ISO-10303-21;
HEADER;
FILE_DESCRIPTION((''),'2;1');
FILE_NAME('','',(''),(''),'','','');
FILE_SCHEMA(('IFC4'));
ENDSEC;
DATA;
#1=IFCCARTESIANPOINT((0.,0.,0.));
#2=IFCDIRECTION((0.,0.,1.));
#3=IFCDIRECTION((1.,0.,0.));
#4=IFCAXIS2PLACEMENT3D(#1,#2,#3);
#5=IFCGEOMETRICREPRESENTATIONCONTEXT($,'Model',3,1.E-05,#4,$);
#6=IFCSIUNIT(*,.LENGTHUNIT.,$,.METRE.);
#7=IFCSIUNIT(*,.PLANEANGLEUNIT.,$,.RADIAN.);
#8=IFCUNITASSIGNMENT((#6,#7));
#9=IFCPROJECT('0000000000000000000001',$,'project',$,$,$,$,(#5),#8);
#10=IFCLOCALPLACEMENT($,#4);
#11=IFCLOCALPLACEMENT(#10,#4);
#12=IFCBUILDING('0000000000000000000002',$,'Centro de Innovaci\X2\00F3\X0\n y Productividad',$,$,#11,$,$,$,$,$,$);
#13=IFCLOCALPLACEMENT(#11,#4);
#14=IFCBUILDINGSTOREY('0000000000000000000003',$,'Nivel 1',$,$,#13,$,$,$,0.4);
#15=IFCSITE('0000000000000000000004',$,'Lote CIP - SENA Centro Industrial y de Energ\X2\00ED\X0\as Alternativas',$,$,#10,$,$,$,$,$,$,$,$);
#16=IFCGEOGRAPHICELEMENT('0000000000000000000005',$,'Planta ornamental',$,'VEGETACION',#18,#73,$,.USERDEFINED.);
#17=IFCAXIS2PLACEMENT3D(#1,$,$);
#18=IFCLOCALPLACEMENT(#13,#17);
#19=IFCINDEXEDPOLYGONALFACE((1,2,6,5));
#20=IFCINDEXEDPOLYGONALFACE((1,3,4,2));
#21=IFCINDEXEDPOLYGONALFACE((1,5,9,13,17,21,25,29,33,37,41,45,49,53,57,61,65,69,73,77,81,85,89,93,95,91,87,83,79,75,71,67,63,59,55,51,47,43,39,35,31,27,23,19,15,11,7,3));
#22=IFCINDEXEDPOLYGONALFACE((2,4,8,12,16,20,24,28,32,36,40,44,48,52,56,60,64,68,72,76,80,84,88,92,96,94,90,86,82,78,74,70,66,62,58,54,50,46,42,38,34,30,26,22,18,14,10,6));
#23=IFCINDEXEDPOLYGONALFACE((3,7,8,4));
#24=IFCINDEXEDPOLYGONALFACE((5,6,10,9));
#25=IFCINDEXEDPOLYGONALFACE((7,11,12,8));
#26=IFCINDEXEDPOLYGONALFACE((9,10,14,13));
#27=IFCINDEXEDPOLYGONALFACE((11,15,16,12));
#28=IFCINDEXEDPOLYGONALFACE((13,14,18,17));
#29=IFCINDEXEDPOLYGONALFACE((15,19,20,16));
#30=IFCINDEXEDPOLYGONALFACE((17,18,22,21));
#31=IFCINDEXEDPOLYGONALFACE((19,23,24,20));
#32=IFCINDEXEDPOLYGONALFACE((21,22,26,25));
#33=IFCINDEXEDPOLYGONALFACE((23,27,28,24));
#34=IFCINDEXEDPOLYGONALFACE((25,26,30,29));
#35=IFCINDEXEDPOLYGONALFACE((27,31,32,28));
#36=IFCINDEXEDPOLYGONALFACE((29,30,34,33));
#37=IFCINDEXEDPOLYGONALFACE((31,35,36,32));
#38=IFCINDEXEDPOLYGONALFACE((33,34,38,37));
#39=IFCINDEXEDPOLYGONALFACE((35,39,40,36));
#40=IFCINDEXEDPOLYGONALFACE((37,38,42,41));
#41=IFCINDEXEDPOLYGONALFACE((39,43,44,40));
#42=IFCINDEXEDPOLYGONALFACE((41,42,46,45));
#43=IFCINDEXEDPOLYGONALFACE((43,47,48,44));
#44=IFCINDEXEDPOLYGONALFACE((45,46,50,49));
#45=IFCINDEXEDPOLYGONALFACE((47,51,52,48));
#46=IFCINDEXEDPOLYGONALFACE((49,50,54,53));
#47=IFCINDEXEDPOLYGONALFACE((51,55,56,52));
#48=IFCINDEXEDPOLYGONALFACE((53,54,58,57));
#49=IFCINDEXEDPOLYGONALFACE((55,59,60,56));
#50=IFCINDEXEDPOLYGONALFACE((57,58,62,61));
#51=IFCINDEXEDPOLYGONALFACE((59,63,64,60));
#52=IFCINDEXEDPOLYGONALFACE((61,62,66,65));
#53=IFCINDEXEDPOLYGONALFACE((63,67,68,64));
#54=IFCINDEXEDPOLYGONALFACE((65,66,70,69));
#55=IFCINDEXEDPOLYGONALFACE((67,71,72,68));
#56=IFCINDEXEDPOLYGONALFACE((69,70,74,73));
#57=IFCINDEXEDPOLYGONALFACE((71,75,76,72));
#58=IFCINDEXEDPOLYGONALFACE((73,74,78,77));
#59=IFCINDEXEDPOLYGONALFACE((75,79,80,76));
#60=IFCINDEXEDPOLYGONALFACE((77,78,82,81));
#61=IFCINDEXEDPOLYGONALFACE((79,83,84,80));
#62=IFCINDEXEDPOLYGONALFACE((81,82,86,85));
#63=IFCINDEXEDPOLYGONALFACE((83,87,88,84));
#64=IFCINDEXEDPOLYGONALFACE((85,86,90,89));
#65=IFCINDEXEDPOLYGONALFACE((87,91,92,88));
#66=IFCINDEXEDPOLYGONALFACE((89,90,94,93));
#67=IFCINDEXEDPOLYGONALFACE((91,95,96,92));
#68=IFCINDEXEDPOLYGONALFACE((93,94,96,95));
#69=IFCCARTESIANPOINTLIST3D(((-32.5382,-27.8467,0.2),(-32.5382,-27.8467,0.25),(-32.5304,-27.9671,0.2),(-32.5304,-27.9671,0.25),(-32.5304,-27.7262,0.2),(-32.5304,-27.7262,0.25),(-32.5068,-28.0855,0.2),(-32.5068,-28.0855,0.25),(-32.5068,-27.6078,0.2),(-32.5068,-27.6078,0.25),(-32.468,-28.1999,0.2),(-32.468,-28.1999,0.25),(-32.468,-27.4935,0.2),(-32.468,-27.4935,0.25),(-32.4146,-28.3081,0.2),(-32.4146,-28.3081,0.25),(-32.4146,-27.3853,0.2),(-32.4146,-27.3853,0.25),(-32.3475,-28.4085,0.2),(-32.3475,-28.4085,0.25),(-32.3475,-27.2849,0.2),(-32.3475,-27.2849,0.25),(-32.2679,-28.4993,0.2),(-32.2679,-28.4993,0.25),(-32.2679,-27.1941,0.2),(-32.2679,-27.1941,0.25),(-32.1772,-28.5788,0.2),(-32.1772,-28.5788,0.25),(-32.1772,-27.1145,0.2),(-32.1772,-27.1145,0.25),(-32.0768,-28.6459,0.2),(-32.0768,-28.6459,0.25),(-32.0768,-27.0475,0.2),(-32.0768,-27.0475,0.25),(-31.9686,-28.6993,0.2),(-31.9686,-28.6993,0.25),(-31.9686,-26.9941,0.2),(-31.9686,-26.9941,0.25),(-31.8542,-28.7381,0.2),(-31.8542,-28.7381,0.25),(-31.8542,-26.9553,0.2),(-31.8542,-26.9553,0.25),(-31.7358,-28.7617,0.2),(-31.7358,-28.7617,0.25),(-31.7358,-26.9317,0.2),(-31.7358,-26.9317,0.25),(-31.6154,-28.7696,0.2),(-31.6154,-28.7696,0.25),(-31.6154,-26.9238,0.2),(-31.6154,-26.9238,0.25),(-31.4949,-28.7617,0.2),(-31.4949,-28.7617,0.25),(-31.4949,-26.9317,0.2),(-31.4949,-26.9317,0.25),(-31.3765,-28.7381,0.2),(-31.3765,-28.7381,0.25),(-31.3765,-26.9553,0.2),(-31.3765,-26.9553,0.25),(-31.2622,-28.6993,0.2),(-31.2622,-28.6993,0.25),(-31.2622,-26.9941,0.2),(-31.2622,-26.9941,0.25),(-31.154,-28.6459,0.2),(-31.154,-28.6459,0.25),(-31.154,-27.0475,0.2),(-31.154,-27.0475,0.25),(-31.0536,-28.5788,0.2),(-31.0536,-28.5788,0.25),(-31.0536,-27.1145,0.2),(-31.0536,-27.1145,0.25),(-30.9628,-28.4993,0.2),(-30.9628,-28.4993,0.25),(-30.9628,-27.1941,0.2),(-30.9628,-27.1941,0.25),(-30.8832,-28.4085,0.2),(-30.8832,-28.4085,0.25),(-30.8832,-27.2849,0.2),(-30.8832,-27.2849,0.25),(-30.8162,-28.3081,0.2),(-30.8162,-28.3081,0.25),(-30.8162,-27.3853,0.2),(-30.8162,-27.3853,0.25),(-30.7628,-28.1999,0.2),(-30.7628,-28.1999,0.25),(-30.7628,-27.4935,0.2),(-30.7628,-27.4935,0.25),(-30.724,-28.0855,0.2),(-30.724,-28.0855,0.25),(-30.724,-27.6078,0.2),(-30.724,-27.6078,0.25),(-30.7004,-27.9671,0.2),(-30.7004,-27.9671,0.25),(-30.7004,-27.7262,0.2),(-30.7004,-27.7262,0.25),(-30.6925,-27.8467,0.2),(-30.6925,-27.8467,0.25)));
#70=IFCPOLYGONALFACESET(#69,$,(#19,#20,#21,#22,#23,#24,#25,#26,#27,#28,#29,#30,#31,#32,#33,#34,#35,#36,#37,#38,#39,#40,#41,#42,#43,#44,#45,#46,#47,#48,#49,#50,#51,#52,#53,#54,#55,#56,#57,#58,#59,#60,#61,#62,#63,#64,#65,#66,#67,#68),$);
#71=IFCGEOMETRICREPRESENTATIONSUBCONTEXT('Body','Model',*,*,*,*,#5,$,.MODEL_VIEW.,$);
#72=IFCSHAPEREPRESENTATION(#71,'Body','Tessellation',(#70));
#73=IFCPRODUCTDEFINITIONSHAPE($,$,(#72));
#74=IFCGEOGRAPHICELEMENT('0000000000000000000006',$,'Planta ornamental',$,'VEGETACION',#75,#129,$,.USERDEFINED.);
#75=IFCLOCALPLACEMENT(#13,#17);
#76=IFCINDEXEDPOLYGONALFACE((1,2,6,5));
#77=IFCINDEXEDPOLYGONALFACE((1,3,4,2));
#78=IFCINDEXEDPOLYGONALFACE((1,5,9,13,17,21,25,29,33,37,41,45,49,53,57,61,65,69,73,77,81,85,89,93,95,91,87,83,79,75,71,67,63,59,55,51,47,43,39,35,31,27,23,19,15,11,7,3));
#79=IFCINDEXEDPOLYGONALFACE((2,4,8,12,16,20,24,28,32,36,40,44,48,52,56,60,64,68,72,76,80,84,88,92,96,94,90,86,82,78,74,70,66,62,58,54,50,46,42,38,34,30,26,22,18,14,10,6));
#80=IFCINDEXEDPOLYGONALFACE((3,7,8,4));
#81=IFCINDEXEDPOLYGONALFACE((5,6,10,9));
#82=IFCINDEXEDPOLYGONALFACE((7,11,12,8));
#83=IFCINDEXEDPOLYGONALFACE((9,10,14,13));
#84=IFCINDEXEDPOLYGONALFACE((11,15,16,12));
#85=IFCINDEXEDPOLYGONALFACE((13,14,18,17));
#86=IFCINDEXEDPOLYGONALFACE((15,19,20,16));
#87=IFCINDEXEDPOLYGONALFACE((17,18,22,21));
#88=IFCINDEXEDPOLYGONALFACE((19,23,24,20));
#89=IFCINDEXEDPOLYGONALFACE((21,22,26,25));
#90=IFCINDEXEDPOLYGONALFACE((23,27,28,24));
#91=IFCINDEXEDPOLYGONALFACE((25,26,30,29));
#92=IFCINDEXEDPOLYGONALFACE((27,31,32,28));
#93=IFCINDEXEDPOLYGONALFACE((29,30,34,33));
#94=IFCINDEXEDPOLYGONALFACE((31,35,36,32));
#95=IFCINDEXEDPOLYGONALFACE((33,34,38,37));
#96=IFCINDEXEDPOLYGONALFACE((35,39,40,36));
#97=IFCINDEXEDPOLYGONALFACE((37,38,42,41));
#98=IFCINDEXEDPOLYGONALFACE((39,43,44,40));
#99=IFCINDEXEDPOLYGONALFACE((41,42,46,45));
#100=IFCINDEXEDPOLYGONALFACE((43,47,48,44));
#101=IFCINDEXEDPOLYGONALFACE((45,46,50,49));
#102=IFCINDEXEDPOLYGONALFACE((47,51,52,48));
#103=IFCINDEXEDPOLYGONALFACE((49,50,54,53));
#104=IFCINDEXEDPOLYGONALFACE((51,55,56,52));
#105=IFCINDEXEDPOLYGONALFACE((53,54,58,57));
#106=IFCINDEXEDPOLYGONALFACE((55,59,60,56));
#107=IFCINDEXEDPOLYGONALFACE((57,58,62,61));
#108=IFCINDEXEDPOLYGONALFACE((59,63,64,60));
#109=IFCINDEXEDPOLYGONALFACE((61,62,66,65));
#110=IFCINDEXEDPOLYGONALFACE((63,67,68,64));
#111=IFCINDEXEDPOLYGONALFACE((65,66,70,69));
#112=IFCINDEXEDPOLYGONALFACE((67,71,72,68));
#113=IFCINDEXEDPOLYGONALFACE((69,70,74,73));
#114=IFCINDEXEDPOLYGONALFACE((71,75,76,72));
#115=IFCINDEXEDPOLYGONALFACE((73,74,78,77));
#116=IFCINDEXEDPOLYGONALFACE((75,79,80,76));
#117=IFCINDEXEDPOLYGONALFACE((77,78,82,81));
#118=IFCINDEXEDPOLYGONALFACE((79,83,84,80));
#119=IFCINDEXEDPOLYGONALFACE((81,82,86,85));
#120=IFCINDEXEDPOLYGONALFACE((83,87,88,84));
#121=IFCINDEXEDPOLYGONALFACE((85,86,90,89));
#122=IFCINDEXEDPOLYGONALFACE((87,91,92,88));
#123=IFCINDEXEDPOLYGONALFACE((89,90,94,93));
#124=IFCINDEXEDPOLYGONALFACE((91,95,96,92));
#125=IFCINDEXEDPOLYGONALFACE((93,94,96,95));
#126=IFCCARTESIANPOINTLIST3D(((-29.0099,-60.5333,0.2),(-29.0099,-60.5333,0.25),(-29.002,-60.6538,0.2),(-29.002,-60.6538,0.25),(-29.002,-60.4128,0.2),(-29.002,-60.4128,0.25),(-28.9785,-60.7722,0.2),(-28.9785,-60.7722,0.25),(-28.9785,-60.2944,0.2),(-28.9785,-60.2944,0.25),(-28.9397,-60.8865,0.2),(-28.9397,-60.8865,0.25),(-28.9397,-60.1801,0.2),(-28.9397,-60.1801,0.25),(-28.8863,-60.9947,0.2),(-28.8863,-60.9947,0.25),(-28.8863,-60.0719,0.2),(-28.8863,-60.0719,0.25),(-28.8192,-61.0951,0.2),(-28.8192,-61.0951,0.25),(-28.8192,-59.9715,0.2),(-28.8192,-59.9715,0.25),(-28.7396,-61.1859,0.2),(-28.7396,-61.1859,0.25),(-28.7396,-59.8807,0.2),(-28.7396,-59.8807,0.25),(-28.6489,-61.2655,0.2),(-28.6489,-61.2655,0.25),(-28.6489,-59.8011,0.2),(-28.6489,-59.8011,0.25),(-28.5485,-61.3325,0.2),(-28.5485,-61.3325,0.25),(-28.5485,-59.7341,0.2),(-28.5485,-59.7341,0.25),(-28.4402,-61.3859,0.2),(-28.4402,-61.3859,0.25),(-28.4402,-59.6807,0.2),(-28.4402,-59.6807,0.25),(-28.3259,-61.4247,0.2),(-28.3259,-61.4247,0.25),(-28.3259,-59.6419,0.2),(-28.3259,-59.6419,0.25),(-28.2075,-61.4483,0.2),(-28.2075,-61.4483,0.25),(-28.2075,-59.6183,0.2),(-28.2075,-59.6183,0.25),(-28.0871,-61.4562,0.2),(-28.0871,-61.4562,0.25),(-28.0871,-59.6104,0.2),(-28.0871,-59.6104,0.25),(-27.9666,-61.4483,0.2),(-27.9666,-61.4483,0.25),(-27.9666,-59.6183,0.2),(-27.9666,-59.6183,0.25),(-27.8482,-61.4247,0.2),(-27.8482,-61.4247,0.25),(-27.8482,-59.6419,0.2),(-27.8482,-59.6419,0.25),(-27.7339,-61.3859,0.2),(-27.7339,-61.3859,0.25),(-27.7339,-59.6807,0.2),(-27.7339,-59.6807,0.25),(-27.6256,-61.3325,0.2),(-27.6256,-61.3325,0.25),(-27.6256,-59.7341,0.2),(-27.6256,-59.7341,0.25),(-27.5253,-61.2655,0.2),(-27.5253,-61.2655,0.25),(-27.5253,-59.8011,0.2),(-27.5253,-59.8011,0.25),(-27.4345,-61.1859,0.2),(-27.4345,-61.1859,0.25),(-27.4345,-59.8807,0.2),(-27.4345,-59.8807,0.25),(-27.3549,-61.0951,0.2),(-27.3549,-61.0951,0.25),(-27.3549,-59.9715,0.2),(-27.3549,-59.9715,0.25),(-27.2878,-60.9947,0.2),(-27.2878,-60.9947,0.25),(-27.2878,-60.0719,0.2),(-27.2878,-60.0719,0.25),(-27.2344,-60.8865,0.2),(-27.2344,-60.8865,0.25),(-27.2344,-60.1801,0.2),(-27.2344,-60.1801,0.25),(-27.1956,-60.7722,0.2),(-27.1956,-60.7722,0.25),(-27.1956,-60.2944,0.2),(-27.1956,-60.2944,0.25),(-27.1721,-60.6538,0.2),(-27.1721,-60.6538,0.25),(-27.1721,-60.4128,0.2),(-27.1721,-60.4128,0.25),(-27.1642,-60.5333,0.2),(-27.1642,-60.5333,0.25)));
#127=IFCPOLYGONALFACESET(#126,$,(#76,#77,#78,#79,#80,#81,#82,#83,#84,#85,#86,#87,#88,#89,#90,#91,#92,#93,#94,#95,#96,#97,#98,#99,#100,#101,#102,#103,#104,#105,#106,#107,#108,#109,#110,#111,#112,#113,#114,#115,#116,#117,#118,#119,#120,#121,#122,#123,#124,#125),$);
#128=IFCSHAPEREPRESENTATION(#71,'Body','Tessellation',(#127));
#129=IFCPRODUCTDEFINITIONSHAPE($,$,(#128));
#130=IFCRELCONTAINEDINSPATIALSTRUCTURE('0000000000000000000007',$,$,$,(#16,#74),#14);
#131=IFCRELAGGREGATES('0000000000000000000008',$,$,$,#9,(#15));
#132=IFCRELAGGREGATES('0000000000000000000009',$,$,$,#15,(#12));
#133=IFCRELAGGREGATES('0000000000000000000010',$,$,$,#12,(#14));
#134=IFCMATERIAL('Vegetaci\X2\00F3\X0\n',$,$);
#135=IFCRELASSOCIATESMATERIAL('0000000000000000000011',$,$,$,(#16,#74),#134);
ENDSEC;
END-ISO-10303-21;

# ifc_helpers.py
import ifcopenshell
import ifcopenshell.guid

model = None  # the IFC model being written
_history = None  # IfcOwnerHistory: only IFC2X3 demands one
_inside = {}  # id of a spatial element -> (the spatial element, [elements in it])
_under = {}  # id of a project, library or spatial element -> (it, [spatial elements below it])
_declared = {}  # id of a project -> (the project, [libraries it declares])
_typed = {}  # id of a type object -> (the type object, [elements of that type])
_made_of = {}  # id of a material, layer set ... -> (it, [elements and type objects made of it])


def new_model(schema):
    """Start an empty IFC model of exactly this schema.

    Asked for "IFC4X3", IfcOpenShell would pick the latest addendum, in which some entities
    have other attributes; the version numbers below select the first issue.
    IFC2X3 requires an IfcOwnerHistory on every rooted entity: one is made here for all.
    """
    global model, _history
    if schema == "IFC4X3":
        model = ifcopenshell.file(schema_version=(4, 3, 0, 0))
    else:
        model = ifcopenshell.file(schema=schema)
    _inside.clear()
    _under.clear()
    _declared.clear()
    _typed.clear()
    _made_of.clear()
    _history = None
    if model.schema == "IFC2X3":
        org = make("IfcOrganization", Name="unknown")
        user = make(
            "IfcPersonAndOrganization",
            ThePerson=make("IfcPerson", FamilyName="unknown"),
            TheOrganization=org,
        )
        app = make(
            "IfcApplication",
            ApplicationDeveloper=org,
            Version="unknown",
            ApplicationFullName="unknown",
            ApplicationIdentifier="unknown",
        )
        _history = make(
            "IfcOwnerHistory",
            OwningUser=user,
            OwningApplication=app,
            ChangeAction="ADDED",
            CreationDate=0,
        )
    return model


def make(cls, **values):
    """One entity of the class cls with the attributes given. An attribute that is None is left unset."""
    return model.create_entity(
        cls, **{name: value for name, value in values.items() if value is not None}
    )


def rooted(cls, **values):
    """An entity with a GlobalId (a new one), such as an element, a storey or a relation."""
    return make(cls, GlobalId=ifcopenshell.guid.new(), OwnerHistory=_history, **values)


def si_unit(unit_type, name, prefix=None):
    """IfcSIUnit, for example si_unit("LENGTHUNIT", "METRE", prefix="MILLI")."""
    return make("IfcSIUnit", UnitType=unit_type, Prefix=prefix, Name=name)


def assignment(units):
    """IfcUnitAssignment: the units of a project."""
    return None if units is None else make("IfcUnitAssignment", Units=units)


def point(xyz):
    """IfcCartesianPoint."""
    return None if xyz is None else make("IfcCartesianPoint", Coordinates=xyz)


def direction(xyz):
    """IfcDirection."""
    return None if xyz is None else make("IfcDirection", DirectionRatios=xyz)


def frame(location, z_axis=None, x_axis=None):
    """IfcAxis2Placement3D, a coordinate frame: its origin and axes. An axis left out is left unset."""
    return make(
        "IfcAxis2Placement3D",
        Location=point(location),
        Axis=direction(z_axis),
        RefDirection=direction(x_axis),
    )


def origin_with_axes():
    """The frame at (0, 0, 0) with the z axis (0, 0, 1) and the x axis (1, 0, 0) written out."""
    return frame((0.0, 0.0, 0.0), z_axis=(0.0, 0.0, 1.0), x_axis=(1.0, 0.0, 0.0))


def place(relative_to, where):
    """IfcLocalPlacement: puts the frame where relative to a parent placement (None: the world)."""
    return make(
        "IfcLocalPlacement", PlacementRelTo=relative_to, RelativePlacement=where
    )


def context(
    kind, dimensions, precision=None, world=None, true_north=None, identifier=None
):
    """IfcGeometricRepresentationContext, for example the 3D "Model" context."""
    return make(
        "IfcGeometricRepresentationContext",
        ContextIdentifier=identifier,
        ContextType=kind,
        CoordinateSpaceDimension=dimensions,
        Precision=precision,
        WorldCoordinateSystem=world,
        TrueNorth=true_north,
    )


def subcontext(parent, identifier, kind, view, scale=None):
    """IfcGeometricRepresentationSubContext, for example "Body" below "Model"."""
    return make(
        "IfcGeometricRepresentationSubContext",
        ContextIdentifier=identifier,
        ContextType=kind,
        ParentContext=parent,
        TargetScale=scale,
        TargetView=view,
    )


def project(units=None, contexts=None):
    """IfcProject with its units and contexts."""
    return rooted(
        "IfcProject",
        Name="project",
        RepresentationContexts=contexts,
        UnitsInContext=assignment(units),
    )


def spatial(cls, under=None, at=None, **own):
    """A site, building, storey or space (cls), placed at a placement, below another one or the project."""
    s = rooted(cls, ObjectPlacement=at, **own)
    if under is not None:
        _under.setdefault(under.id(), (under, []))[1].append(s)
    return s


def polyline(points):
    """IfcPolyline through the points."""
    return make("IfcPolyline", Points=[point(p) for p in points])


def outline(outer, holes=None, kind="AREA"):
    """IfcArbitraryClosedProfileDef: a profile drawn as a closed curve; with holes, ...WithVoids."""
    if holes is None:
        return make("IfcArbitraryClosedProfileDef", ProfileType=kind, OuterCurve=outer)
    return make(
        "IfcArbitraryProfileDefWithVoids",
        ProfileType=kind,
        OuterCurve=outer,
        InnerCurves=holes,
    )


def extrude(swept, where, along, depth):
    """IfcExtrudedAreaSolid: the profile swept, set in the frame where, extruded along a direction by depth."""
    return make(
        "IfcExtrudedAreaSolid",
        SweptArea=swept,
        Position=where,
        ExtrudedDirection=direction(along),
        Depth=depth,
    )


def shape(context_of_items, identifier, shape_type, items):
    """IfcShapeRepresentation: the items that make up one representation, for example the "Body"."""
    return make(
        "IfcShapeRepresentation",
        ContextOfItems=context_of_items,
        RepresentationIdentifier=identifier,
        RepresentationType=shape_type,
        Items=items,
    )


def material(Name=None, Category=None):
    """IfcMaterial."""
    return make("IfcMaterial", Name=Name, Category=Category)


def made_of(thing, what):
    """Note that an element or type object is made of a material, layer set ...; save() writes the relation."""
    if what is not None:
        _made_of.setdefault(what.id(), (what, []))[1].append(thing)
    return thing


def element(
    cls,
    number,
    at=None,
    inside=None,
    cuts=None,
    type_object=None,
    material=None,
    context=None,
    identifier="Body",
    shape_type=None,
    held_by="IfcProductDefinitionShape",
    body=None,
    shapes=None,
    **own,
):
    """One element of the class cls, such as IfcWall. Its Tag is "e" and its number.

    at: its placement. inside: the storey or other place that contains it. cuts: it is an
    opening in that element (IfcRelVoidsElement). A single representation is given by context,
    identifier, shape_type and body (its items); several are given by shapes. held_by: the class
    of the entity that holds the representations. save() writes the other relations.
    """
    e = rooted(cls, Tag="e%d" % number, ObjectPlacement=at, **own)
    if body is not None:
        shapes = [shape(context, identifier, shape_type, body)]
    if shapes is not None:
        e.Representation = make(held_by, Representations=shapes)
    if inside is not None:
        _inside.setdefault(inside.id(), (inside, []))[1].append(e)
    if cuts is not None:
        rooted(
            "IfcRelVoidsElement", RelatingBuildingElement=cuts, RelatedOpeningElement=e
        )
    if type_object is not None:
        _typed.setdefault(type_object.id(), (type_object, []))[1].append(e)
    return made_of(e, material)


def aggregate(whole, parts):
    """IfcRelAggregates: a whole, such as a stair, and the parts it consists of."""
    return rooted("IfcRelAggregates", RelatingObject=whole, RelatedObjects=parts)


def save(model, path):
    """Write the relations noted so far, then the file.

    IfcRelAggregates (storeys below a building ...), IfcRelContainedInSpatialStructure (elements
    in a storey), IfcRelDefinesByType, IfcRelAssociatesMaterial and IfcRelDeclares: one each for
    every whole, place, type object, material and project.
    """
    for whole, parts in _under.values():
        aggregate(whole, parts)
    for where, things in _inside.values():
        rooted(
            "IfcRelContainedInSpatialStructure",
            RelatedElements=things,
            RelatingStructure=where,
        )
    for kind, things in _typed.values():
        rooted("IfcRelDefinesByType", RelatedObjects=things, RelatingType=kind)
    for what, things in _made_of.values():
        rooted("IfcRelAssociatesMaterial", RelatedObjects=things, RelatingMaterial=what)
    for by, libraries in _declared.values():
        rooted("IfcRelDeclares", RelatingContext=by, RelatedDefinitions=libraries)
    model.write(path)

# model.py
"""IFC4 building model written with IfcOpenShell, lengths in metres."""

from ifc_helpers import new_model, si_unit, frame, origin_with_axes, place, context, subcontext, project, spatial, polyline, outline, extrude, material, element, save


model = new_model("IFC4")

# Units and contexts
model_context = context("Model", 3, precision=1e-05, world=origin_with_axes())
body_context = subcontext(model_context, "Body", "Model", "MODEL_VIEW")
ifc_project = project(units=[si_unit("LENGTHUNIT", "METRE"), si_unit("PLANEANGLEUNIT", "RADIAN")], contexts=[model_context])

# Site, building, storey
site_placement = place(None, origin_with_axes())
site = spatial("IfcSite", under=ifc_project, at=site_placement, Name="Lote CIP - SENA Centro Industrial y de Energías Alternativas")
building_placement = place(site_placement, origin_with_axes())
building = spatial("IfcBuilding", under=site, at=building_placement, Name="Centro de Innovación y Productividad")
storey_placement = place(building_placement, origin_with_axes())
storey = spatial("IfcBuildingStorey", under=building, at=storey_placement, Name="Nivel 1", Elevation=0.4)

# Geographic elements
ifc_material_1 = material(Name="Vegetación")
geographic_element_1_placement = place(storey_placement, origin_with_axes())
element("IfcGeographicElement", 1, at=geographic_element_1_placement, inside=storey, material=ifc_material_1, Name="Planta ornamental", ObjectType="VEGETACION", PredefinedType="USERDEFINED", context=body_context, shape_type="SweptSolid", body=[
    extrude(outline(polyline([(-30.6925, -27.8467), (-30.7004, -27.9671), (-30.724, -28.0855), (-30.7628, -28.1999), (-30.8162, -28.3081), (-30.8832, -28.4085), (-30.9628, -28.4993), (-31.0536, -28.5788), (-31.154, -28.6459), (-31.2622, -28.6993), (-31.3765, -28.7381), (-31.4949, -28.7617), (-31.6154, -28.7696), (-31.7358, -28.7617), (-31.8542, -28.7381), (-31.9686, -28.6993), (-32.0768, -28.6459), (-32.1772, -28.5788), (-32.2679, -28.4993), (-32.3475, -28.4085), (-32.4146, -28.3081), (-32.468, -28.1999), (-32.5068, -28.0855), (-32.5304, -27.9671), (-32.5382, -27.8467), (-32.5304, -27.7262), (-32.5068, -27.6078), (-32.468, -27.4935), (-32.4146, -27.3853), (-32.3475, -27.2849), (-32.2679, -27.1941), (-32.1772, -27.1145), (-32.0768, -27.0475), (-31.9686, -26.9941), (-31.8542, -26.9553), (-31.7358, -26.9317), (-31.6154, -26.9238), (-31.4949, -26.9317), (-31.3765, -26.9553), (-31.2622, -26.9941), (-31.154, -27.0475), (-31.0536, -27.1145), (-30.9628, -27.1941), (-30.8832, -27.2849), (-30.8162, -27.3853), (-30.7628, -27.4935), (-30.724, -27.6078), (-30.7004, -27.7262), (-30.6925, -27.8467)])), frame((0.0, 0.0, 0.2)), (0.0, 0.0, 1.0), 0.05),
])
geographic_element_2_placement = place(storey_placement, origin_with_axes())
element("IfcGeographicElement", 2, at=geographic_element_2_placement, inside=storey, material=ifc_material_1, Name="Planta ornamental", ObjectType="VEGETACION", PredefinedType="USERDEFINED", context=body_context, shape_type="SweptSolid", body=[
    extrude(outline(polyline([(-27.1642, -60.5333), (-27.1721, -60.6538), (-27.1956, -60.7722), (-27.2344, -60.8865), (-27.2878, -60.9947), (-27.3549, -61.0951), (-27.4345, -61.1859), (-27.5253, -61.2655), (-27.6256, -61.3325), (-27.7339, -61.3859), (-27.8482, -61.4247), (-27.9666, -61.4483), (-28.0871, -61.4562), (-28.2075, -61.4483), (-28.3259, -61.4247), (-28.4402, -61.3859), (-28.5485, -61.3325), (-28.6489, -61.2655), (-28.7396, -61.1859), (-28.8192, -61.0951), (-28.8863, -60.9947), (-28.9397, -60.8865), (-28.9785, -60.7722), (-29.002, -60.6538), (-29.0099, -60.5333), (-29.002, -60.4128), (-28.9785, -60.2944), (-28.9397, -60.1801), (-28.8863, -60.0719), (-28.8192, -59.9715), (-28.7396, -59.8807), (-28.6489, -59.8011), (-28.5485, -59.7341), (-28.4402, -59.6807), (-28.3259, -59.6419), (-28.2075, -59.6183), (-28.0871, -59.6104), (-27.9666, -59.6183), (-27.8482, -59.6419), (-27.7339, -59.6807), (-27.6256, -59.7341), (-27.5253, -59.8011), (-27.4345, -59.8807), (-27.3549, -59.9715), (-27.2878, -60.0719), (-27.2344, -60.1801), (-27.1956, -60.2944), (-27.1721, -60.4128), (-27.1642, -60.5333)])), frame((0.0, 0.0, 0.2)), (0.0, 0.0, 1.0), 0.05),
])

save(model, "model.ifc")
